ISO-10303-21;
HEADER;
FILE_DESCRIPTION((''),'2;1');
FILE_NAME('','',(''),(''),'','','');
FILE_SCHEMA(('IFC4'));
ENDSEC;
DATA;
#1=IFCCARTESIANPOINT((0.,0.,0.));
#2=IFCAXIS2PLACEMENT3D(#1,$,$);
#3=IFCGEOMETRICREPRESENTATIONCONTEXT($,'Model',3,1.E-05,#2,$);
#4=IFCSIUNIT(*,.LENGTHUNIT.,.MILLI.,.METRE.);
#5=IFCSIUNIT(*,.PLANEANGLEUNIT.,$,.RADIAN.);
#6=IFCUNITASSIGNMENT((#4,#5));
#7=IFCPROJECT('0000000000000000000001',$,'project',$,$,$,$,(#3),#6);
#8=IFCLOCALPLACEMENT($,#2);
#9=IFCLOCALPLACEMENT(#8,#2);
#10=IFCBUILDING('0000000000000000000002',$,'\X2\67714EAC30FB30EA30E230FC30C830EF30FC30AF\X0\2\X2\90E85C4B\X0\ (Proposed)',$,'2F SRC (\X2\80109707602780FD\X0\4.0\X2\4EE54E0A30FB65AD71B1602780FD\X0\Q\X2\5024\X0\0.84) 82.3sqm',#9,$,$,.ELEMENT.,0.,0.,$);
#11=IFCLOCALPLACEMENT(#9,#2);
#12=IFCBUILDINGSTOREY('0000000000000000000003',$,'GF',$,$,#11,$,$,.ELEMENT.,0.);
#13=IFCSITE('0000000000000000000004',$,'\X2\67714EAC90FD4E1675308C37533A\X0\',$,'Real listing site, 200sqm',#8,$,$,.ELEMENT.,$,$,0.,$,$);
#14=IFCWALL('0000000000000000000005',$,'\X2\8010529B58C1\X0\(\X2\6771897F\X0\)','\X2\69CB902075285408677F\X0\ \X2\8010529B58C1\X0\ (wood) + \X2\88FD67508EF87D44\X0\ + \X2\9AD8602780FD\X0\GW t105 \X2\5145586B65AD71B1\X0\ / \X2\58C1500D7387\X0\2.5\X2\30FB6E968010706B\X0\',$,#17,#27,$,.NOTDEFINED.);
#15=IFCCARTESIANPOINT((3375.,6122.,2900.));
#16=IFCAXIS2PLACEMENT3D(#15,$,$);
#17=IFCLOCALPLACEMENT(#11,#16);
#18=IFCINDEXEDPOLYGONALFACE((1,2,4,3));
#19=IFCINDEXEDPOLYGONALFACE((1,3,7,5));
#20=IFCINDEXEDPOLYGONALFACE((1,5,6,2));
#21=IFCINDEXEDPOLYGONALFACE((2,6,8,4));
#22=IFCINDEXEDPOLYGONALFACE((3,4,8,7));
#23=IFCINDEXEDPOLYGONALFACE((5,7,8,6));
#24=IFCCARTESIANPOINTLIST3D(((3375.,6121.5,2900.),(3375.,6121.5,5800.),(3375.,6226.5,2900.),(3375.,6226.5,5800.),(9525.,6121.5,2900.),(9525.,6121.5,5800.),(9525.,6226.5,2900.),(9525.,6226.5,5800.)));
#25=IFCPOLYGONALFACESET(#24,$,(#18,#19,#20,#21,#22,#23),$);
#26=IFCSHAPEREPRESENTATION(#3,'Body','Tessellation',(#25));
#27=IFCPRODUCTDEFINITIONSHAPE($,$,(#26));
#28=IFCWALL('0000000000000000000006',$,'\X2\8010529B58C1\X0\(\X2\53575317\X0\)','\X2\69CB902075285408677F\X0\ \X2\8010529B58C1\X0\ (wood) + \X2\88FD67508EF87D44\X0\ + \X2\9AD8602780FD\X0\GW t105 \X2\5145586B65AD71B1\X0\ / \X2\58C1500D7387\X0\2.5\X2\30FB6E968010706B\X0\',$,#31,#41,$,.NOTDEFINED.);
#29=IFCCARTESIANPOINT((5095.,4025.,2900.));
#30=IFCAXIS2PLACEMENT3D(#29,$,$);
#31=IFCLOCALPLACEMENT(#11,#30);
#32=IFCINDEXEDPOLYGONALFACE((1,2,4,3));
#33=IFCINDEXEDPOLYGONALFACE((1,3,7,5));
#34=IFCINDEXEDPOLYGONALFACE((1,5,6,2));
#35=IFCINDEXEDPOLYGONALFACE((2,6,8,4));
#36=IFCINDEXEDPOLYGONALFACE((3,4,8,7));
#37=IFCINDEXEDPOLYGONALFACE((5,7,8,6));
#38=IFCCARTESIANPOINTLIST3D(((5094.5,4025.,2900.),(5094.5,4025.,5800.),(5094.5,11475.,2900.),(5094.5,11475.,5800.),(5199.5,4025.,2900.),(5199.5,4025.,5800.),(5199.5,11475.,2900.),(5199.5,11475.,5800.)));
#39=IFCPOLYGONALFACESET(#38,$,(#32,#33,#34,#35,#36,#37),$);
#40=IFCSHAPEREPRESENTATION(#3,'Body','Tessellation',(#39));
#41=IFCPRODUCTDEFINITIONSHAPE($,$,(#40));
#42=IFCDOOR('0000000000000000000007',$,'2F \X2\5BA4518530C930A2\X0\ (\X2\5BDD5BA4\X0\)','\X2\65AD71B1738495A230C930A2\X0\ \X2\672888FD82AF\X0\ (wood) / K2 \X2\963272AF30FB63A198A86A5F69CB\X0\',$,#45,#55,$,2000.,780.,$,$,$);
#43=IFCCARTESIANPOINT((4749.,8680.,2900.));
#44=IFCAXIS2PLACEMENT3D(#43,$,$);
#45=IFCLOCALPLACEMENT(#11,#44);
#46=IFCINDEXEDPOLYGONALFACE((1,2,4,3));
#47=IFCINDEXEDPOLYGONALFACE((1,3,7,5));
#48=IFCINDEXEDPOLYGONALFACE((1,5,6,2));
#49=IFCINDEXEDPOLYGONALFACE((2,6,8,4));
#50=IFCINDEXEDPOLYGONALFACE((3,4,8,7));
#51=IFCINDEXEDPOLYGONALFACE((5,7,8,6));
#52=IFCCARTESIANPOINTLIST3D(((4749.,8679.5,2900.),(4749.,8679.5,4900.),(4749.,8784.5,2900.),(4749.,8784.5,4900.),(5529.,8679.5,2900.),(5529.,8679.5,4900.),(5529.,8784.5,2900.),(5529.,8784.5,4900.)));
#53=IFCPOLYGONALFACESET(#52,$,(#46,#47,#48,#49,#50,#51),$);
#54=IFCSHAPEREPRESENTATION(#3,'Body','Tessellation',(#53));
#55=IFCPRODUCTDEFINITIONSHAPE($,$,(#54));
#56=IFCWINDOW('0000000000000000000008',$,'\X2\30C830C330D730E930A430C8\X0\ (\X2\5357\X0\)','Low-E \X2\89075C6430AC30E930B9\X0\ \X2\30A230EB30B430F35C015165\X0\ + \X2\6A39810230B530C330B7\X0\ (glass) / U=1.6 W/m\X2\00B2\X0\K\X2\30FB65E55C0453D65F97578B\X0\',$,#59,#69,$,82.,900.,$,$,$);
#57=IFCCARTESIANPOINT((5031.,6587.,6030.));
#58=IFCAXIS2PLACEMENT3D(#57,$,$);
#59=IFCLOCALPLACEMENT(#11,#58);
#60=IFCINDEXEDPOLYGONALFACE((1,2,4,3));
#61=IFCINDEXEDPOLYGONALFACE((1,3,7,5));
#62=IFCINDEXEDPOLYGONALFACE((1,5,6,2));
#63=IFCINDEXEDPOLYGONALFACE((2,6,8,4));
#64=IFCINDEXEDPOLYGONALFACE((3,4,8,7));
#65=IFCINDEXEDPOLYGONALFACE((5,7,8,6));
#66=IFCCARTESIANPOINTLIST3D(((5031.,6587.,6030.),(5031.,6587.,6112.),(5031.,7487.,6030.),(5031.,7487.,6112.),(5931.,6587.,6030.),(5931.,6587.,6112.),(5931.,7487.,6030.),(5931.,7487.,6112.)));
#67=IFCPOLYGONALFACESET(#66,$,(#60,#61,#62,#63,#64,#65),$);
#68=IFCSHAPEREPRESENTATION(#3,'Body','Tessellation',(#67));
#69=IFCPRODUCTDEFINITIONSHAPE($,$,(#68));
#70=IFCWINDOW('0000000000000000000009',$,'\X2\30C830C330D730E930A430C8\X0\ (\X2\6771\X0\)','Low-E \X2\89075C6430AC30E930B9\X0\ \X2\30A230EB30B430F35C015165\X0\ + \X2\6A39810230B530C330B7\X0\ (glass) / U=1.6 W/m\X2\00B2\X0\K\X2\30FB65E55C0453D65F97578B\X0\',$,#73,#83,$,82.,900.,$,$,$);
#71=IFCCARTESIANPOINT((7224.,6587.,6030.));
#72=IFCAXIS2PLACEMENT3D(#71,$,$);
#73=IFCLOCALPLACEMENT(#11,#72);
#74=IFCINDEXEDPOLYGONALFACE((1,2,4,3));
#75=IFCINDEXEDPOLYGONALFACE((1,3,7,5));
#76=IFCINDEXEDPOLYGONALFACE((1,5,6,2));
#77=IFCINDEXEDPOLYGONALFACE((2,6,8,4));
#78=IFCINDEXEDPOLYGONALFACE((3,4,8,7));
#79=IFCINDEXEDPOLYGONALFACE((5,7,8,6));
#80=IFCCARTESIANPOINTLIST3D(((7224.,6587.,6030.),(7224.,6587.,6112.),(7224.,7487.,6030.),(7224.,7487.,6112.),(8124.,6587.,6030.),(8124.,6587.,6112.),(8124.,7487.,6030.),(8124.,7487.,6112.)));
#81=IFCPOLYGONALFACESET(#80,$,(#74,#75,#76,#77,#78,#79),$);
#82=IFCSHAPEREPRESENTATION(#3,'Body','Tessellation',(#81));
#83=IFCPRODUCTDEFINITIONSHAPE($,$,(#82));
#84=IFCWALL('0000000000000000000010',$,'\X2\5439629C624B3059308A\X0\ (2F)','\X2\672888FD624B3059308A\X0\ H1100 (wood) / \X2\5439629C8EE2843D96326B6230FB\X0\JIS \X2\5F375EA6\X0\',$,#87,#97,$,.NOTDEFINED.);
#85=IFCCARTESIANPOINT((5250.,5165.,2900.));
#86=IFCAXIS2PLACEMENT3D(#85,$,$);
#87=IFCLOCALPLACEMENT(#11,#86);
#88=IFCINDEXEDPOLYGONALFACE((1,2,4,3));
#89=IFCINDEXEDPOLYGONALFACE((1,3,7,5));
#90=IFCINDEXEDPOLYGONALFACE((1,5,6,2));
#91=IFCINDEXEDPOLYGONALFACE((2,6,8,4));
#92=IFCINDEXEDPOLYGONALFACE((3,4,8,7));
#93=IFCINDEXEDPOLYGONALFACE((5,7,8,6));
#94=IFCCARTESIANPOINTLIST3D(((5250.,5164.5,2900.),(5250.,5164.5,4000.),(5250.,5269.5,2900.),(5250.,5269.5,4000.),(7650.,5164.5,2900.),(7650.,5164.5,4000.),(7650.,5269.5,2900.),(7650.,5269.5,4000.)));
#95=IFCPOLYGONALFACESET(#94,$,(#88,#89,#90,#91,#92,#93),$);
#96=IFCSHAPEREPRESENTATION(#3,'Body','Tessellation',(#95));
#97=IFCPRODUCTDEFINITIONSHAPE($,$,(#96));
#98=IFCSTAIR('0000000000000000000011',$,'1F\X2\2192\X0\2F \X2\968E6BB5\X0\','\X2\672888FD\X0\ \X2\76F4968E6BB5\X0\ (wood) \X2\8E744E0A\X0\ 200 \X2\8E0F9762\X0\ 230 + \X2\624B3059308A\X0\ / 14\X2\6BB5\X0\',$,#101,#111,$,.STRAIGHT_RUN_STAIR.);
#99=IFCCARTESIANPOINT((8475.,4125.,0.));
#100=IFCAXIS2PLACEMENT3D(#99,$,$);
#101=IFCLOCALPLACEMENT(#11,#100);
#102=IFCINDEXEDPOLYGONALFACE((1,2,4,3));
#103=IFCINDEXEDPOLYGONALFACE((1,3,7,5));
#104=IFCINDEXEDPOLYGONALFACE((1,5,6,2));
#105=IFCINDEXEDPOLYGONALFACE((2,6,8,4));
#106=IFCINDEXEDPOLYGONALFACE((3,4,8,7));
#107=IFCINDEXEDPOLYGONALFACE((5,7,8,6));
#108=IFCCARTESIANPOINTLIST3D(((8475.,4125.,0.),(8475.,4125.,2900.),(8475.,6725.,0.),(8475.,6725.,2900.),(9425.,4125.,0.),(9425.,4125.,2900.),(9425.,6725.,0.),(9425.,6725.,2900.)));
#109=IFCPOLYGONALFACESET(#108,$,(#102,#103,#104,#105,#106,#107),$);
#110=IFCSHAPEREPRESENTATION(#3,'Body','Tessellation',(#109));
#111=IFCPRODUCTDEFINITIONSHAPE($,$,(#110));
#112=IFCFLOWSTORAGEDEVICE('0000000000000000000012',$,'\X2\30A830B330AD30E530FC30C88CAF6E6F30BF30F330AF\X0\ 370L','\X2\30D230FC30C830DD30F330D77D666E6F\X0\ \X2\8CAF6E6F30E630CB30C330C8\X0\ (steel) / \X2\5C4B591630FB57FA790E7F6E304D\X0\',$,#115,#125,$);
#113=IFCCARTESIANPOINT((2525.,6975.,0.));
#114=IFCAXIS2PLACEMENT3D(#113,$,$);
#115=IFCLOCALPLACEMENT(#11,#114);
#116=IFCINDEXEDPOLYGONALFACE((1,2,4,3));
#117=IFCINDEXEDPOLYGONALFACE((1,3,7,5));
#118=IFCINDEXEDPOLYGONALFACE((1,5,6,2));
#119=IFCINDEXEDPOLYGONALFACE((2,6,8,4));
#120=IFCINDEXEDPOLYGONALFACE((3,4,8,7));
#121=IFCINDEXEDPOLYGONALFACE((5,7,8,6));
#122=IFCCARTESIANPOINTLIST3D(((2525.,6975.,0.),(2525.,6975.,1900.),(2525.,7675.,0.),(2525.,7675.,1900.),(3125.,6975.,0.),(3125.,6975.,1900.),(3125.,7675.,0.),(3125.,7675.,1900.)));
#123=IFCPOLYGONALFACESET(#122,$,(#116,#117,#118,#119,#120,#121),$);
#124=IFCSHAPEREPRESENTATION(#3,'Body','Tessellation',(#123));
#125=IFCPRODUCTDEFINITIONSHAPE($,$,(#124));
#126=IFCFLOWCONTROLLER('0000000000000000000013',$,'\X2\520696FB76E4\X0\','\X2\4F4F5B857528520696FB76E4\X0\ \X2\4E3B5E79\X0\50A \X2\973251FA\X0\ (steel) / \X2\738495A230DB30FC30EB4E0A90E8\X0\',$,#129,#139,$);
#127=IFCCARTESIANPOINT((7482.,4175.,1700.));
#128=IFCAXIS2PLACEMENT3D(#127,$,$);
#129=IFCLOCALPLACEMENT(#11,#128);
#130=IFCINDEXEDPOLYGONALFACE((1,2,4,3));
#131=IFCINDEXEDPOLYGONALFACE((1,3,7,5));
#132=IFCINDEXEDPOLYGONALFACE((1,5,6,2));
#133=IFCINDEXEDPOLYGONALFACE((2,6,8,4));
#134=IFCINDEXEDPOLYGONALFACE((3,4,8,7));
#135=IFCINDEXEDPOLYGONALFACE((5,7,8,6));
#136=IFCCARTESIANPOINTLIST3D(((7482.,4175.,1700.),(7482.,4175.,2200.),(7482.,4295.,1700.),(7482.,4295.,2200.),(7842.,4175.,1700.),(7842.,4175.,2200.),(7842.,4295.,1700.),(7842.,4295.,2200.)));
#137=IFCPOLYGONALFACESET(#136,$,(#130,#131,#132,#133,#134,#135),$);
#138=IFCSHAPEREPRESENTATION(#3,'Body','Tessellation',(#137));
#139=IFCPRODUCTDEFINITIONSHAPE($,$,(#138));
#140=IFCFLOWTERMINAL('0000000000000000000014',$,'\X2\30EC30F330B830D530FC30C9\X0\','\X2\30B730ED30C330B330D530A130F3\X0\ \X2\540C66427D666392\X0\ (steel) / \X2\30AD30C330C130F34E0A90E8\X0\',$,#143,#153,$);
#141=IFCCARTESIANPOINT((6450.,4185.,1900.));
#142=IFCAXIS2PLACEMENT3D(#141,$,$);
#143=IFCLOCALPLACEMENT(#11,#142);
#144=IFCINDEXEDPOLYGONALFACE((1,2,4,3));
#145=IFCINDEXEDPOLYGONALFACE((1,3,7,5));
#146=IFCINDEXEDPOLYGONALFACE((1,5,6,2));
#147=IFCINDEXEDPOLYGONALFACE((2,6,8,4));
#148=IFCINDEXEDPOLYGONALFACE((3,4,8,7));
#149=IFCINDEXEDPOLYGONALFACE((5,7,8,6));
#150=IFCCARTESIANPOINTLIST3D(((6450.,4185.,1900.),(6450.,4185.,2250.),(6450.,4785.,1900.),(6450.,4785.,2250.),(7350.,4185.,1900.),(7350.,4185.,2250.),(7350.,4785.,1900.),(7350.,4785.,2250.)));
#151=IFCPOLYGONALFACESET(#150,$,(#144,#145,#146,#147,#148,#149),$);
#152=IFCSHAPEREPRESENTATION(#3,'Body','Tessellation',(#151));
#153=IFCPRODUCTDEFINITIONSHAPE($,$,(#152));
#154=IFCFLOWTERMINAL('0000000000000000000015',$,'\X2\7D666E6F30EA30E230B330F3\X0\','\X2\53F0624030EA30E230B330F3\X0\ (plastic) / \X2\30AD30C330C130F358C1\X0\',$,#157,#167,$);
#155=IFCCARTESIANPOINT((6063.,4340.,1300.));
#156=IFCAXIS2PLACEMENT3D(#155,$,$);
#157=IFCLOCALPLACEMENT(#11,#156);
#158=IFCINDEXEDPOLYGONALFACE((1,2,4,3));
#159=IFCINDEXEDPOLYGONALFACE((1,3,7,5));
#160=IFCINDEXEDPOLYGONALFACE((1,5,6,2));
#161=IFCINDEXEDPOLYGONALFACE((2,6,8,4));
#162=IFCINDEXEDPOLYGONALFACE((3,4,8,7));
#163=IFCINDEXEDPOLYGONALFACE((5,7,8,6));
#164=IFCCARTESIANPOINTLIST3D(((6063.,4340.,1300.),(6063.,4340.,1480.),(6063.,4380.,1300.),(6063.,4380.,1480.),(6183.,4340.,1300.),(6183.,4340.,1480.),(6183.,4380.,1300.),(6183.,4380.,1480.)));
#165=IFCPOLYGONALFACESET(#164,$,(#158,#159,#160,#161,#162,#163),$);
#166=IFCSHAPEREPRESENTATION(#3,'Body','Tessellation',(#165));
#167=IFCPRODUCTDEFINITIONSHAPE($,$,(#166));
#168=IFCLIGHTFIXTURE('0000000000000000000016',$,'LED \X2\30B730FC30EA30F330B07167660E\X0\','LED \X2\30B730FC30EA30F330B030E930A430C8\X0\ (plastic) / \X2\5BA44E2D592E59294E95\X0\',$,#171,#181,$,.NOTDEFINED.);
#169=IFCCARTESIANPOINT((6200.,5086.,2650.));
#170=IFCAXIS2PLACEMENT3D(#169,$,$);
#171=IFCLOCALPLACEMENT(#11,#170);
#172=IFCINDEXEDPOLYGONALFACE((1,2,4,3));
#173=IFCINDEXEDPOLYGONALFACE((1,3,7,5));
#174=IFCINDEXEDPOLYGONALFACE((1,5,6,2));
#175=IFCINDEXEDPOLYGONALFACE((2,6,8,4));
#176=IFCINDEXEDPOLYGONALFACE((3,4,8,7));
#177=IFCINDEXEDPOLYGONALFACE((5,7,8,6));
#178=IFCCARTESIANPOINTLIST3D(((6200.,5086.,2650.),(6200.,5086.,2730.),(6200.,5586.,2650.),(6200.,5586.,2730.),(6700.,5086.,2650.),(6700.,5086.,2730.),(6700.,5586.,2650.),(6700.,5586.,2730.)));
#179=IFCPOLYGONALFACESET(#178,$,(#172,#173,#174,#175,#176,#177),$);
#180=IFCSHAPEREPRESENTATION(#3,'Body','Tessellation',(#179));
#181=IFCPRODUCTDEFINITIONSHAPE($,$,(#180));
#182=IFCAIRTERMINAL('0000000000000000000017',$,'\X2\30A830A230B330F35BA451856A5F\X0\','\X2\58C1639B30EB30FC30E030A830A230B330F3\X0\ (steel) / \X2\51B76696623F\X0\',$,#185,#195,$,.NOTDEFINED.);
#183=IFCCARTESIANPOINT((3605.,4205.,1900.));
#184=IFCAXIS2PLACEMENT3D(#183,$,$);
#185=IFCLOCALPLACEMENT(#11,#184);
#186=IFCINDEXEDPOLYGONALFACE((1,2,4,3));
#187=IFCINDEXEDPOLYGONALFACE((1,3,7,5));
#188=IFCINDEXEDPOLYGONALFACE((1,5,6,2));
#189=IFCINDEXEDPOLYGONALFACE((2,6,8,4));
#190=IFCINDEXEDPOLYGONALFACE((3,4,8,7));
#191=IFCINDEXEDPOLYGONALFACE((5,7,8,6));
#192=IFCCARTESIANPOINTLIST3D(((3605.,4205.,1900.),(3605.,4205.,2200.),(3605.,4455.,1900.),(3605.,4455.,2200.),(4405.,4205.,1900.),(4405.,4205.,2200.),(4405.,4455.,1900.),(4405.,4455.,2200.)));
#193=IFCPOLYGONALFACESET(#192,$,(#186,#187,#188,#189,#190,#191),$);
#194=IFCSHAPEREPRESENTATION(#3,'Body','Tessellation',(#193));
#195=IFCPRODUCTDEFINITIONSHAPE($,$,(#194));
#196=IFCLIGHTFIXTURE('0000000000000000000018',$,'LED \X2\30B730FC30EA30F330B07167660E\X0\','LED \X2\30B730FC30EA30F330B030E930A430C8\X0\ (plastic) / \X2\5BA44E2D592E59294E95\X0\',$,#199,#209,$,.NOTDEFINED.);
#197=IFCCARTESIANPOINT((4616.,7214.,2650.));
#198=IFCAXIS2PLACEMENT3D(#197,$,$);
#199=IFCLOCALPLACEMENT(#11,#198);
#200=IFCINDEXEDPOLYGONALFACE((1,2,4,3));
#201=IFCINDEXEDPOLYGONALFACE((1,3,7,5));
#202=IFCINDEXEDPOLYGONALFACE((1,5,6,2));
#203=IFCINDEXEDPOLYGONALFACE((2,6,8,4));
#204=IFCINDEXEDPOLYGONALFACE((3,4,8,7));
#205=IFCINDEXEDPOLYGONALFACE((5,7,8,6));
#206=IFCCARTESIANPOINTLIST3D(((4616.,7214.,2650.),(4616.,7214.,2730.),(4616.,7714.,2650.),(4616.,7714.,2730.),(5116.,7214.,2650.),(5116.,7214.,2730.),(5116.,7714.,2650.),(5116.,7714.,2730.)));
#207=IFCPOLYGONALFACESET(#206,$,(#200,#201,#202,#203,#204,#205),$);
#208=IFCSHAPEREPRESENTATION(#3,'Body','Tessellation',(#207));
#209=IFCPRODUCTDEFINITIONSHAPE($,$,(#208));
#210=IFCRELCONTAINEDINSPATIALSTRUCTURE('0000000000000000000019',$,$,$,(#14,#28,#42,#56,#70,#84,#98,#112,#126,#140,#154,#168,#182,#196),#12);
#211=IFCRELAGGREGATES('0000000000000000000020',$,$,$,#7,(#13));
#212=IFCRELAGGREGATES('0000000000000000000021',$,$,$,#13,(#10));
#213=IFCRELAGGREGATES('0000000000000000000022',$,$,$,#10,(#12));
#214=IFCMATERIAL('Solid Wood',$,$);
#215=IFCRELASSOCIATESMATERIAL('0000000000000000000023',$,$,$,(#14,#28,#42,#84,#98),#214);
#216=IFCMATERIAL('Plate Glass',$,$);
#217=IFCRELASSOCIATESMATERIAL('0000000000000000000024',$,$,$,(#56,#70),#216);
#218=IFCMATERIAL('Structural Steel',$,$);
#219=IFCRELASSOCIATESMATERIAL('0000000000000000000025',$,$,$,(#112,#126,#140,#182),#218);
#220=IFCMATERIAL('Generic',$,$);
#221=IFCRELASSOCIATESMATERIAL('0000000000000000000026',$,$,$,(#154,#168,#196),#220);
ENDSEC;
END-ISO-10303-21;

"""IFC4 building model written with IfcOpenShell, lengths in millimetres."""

from ifc_helpers import new_model, si_unit, frame, frame_2d, origin, place, context, project, spatial, rectangle, extrude, material, element, fill, save


model = new_model("IFC4")

# Units and contexts
model_context = context("Model", 3, precision=1e-05, world=origin())
ifc_project = project(units=[si_unit("LENGTHUNIT", "METRE", prefix="MILLI"), si_unit("PLANEANGLEUNIT", "RADIAN")], contexts=[model_context])

# Site, building, storey
site_placement = place(None, origin())
site = spatial("IfcSite", under=ifc_project, at=site_placement, Name="東京都世田谷区", ObjectType="Real listing site, 200sqm", CompositionType="ELEMENT", RefElevation=0.0)
building_placement = place(site_placement, origin())
building = spatial("IfcBuilding", under=site, at=building_placement, Name="東京・リモートワーク2部屋 (Proposed)", ObjectType="2F SRC (耐震性能4.0以上・断熱性能Q値0.84) 82.3sqm", CompositionType="ELEMENT", ElevationOfRefHeight=0.0, ElevationOfTerrain=0.0)
storey_placement = place(building_placement, origin())
storey = spatial("IfcBuildingStorey", under=building, at=storey_placement, Name="GF", CompositionType="ELEMENT", Elevation=0.0)

# Shared definitions
ifc_material_1 = material(Name="Solid Wood")

# Wall
wall_1_placement = place(storey_placement, frame((3375.0, 6122.0, 2900.0)))
element("IfcWall", 1, at=wall_1_placement, inside=storey, material=ifc_material_1, Name="耐力壁(東西)", Description="構造用合板 耐力壁 (wood) + 製材軸組 + 高性能GW t105 充填断熱 / 壁倍率2.5・準耐火", PredefinedType="NOTDEFINED", context=model_context, shape_type="SweptSolid", body=[
    extrude(rectangle(XDim=6150.0, YDim=105.0, at=frame_2d((3075.0, 52.0))), frame((3375.0, 6122.0, 2900.0)), (0.0, 0.0, 1.0), 2900.0),
])

# Wall, opening, door
wall_2_placement = place(storey_placement, frame((5095.0, 4025.0, 2900.0)))
wall_2 = element("IfcWall", 2, at=wall_2_placement, inside=storey, material=ifc_material_1, Name="耐力壁(南北)", Description="構造用合板 耐力壁 (wood) + 製材軸組 + 高性能GW t105 充填断熱 / 壁倍率2.5・準耐火", PredefinedType="NOTDEFINED", context=model_context, shape_type="SweptSolid", body=[
    extrude(rectangle(XDim=105.0, YDim=7450.0, at=frame_2d((52.0, 3725.0))), frame((5095.0, 4025.0, 2900.0)), (0.0, 0.0, 1.0), 2900.0),
])
opening_placement = place(storey_placement, frame((4749.0, 8680.0, 2900.0)))
opening = element("IfcOpeningElement", 3, at=opening_placement, cuts=wall_2, PredefinedType="NOTDEFINED", context=model_context, shape_type="SweptSolid", body=[
    extrude(rectangle(XDim=780.0, YDim=105.0, at=frame_2d((390.0, 52.0))), frame((4749.0, 8680.0, 2900.0)), (0.0, 0.0, 1.0), 2000.0),
])
door_placement = place(storey_placement, frame((4749.0, 8680.0, 2900.0)))
door = element("IfcDoor", 4, at=door_placement, inside=storey, material=ifc_material_1, Name="2F 室内ドア (寝室)", Description="断熱玄関ドア 木製芯 (wood) / K2 防犯・採風機構", OverallHeight=2000.0, OverallWidth=780.0, context=model_context, shape_type="SweptSolid", body=[
    extrude(rectangle(XDim=780.0, YDim=105.0, at=frame_2d((390.0, 52.0))), frame((4749.0, 8680.0, 2900.0)), (0.0, 0.0, 1.0), 2000.0),
])
fill(opening, door)

# Windows
ifc_material_2 = material(Name="Plate Glass")
window_1_placement = place(storey_placement, frame((5031.0, 6587.0, 6030.0)))
element("IfcWindow", 5, at=window_1_placement, inside=storey, material=ifc_material_2, Name="トップライト (南)", Description="Low-E 複層ガラス アルゴン封入 + 樹脂サッシ (glass) / U=1.6 W/m²K・日射取得型", OverallHeight=82.0, OverallWidth=900.0, context=model_context, shape_type="SweptSolid", body=[
    extrude(rectangle(XDim=900.0, YDim=900.0, at=frame_2d((450.0, 450.0))), frame((5031.0, 6587.0, 6030.0)), (0.0, 0.0, 1.0), 82.0),
])
window_2_placement = place(storey_placement, frame((7224.0, 6587.0, 6030.0)))
element("IfcWindow", 6, at=window_2_placement, inside=storey, material=ifc_material_2, Name="トップライト (東)", Description="Low-E 複層ガラス アルゴン封入 + 樹脂サッシ (glass) / U=1.6 W/m²K・日射取得型", OverallHeight=82.0, OverallWidth=900.0, context=model_context, shape_type="SweptSolid", body=[
    extrude(rectangle(XDim=900.0, YDim=900.0, at=frame_2d((450.0, 450.0))), frame((7224.0, 6587.0, 6030.0)), (0.0, 0.0, 1.0), 82.0),
])

# Wall
wall_3_placement = place(storey_placement, frame((5250.0, 5165.0, 2900.0)))
element("IfcWall", 7, at=wall_3_placement, inside=storey, material=ifc_material_1, Name="吹抜手すり (2F)", Description="木製手すり H1100 (wood) / 吹抜転落防止・JIS 強度", PredefinedType="NOTDEFINED", context=model_context, shape_type="SweptSolid", body=[
    extrude(rectangle(XDim=2400.0, YDim=105.0, at=frame_2d((1200.0, 52.0))), frame((5250.0, 5165.0, 2900.0)), (0.0, 0.0, 1.0), 1100.0),
])

# Stair
stair_placement = place(storey_placement, frame((8475.0, 4125.0, 0.0)))
element("IfcStair", 8, at=stair_placement, inside=storey, material=ifc_material_1, Name="1F→2F 階段", Description="木製 直階段 (wood) 蹴上 200 踏面 230 + 手すり / 14段", PredefinedType="STRAIGHT_RUN_STAIR", context=model_context, shape_type="SweptSolid", body=[
    extrude(rectangle(XDim=950.0, YDim=2600.0, at=frame_2d((475.0, 1300.0))), frame((8475.0, 4125.0, 0.0)), (0.0, 0.0, 1.0), 2900.0),
])

# Flow storage device
ifc_material_3 = material(Name="Structural Steel")
flow_storage_device_placement = place(storey_placement, frame((2525.0, 6975.0, 0.0)))
element("IfcFlowStorageDevice", 9, at=flow_storage_device_placement, inside=storey, material=ifc_material_3, Name="エコキュート貯湯タンク 370L", Description="ヒートポンプ給湯 貯湯ユニット (steel) / 屋外・基礎置き", context=model_context, shape_type="SweptSolid", body=[
    extrude(rectangle(XDim=600.0, YDim=700.0, at=frame_2d((300.0, 350.0))), frame((2525.0, 6975.0, 0.0)), (0.0, 0.0, 1.0), 1900.0),
])

# Flow controller
flow_controller_placement = place(storey_placement, frame((7482.0, 4175.0, 1700.0)))
element("IfcFlowController", 10, at=flow_controller_placement, inside=storey, material=ifc_material_3, Name="分電盤", Description="住宅用分電盤 主幹50A 露出 (steel) / 玄関ホール上部", context=model_context, shape_type="SweptSolid", body=[
    extrude(rectangle(XDim=360.0, YDim=120.0, at=frame_2d((180.0, 60.0))), frame((7482.0, 4175.0, 1700.0)), (0.0, 0.0, 1.0), 500.0),
])

# Flow terminals
flow_terminal_1_placement = place(storey_placement, frame((6450.0, 4185.0, 1900.0)))
element("IfcFlowTerminal", 11, at=flow_terminal_1_placement, inside=storey, material=ifc_material_3, Name="レンジフード", Description="シロッコファン 同時給排 (steel) / キッチン上部", context=model_context, shape_type="SweptSolid", body=[
    extrude(rectangle(XDim=900.0, YDim=600.0, at=frame_2d((450.0, 300.0))), frame((6450.0, 4185.0, 1900.0)), (0.0, 0.0, 1.0), 350.0),
])
ifc_material_4 = material(Name="Generic")
flow_terminal_2_placement = place(storey_placement, frame((6063.0, 4340.0, 1300.0)))
element("IfcFlowTerminal", 12, at=flow_terminal_2_placement, inside=storey, material=ifc_material_4, Name="給湯リモコン", Description="台所リモコン (plastic) / キッチン壁", context=model_context, shape_type="SweptSolid", body=[
    extrude(rectangle(XDim=120.0, YDim=40.0, at=frame_2d((60.0, 20.0))), frame((6063.0, 4340.0, 1300.0)), (0.0, 0.0, 1.0), 180.0),
])

# Light fixture
light_fixture_1_placement = place(storey_placement, frame((6200.0, 5086.0, 2650.0)))
element("IfcLightFixture", 13, at=light_fixture_1_placement, inside=storey, material=ifc_material_4, Name="LED シーリング照明", Description="LED シーリングライト (plastic) / 室中央天井", PredefinedType="NOTDEFINED", context=model_context, shape_type="SweptSolid", body=[
    extrude(rectangle(XDim=500.0, YDim=500.0, at=frame_2d((250.0, 250.0))), frame((6200.0, 5086.0, 2650.0)), (0.0, 0.0, 1.0), 80.0),
])

# Air terminal
air_terminal_1_placement = place(storey_placement, frame((3605.0, 4205.0, 1900.0)))
element("IfcAirTerminal", 14, at=air_terminal_1_placement, inside=storey, material=ifc_material_3, Name="エアコン室内機", Description="壁掛ルームエアコン (steel) / 冷暖房", PredefinedType="NOTDEFINED", context=model_context, shape_type="SweptSolid", body=[
    extrude(rectangle(XDim=800.0, YDim=250.0, at=frame_2d((400.0, 125.0))), frame((3605.0, 4205.0, 1900.0)), (0.0, 0.0, 1.0), 300.0),
])

# Light fixture
light_fixture_2_placement = place(storey_placement, frame((4616.0, 7214.0, 2650.0)))
element("IfcLightFixture", 15, at=light_fixture_2_placement, inside=storey, material=ifc_material_4, Name="LED シーリング照明", Description="LED シーリングライト (plastic) / 室中央天井", PredefinedType="NOTDEFINED", context=model_context, shape_type="SweptSolid", body=[
    extrude(rectangle(XDim=500.0, YDim=500.0, at=frame_2d((250.0, 250.0))), frame((4616.0, 7214.0, 2650.0)), (0.0, 0.0, 1.0), 80.0),
])

save(model, "model.ifc")
